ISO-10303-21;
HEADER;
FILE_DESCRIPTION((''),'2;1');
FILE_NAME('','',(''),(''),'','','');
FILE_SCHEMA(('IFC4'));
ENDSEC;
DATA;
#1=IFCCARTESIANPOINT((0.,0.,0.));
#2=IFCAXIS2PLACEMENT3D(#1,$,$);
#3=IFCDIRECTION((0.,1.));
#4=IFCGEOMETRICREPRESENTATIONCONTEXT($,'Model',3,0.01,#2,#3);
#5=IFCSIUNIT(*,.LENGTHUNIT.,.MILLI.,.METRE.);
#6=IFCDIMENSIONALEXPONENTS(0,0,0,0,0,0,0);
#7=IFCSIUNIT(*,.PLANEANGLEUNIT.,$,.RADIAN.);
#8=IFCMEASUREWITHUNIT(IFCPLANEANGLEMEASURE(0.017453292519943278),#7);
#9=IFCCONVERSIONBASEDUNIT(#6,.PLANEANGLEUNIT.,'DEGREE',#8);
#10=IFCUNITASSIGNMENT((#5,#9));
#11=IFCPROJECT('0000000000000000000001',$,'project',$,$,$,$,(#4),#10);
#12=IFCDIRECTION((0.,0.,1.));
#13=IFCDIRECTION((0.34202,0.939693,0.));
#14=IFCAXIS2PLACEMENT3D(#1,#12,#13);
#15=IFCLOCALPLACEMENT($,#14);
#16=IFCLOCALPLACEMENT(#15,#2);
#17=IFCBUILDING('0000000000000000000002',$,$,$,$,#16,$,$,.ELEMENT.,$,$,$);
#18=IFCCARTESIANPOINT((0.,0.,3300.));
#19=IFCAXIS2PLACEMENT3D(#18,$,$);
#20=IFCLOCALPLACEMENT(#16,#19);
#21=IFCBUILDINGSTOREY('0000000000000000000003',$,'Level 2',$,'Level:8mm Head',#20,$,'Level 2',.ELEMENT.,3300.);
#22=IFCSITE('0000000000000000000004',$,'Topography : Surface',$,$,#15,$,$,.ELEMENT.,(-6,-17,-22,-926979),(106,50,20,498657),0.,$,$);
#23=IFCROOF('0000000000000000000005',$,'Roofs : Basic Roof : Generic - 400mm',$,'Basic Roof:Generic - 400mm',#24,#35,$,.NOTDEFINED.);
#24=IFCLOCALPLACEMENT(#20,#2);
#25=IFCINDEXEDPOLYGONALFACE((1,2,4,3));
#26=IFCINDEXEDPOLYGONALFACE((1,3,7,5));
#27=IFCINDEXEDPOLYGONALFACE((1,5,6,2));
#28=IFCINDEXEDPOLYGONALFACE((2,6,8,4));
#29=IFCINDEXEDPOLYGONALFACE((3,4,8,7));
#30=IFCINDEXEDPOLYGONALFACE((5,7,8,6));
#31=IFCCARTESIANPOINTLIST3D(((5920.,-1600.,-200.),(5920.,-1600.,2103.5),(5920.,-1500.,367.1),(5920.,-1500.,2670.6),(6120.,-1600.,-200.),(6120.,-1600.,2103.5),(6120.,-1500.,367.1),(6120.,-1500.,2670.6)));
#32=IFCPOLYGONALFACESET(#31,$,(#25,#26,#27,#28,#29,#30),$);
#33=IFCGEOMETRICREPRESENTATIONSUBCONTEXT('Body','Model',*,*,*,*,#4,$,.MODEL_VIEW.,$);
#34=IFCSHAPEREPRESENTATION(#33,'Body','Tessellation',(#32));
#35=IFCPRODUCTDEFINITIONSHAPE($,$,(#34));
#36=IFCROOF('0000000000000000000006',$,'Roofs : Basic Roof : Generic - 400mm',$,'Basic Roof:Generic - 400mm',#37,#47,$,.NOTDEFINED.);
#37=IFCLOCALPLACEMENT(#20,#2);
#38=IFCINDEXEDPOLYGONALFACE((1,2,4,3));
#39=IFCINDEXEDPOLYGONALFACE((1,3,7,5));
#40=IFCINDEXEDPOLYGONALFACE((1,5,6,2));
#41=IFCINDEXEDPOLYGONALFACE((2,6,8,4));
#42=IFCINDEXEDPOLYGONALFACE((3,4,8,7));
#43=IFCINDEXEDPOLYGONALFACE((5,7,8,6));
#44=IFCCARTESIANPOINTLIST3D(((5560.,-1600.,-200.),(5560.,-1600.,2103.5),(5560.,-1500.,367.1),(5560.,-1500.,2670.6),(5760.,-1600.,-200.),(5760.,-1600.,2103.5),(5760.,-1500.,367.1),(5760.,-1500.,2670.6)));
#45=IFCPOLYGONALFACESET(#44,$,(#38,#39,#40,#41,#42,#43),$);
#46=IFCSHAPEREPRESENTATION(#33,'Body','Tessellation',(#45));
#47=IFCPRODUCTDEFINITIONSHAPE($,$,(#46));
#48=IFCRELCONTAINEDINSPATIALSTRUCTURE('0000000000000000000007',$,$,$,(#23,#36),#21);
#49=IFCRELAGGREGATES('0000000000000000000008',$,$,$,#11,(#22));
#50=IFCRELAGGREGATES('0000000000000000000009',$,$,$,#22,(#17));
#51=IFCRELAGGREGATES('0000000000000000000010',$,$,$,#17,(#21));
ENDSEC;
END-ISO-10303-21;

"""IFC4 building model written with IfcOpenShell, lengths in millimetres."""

from ifc_helpers import new_model, entity, si_unit, converted_unit, direction, frame, origin, place, context, subcontext, project, spatial, indexed_curve, outline, extrude, element, save


model = new_model("IFC4")

# Units and contexts
model_context = context("Model", 3, precision=0.01, world=origin(), true_north=direction((0.0, 1.0)))
body_context = subcontext(model_context, "Body", "Model", "MODEL_VIEW")
ifc_project = project(units=[si_unit("LENGTHUNIT", "METRE", prefix="MILLI"), converted_unit("PLANEANGLEUNIT", "DEGREE", entity("IfcPlaneAngleMeasure", 0.017453292519943278), si_unit("PLANEANGLEUNIT", "RADIAN"), dimensions=[0, 0, 0, 0, 0, 0, 0])], contexts=[model_context])

# Site, building, storey
site_placement = place(None, frame((0.0, 0.0, 0.0), z_axis=(0.0, 0.0, 1.0), x_axis=(0.34202, 0.939693, 0.0)))
site = spatial("IfcSite", under=ifc_project, at=site_placement, Name="Topography : Surface", CompositionType="ELEMENT", RefLatitude=(-6, -17, -22, -926979), RefLongitude=(106, 50, 20, 498657), RefElevation=0.0)
building_placement = place(site_placement, origin())
building = spatial("IfcBuilding", under=site, at=building_placement, CompositionType="ELEMENT")
storey_placement = place(building_placement, frame((0.0, 0.0, 3300.0)))
storey = spatial("IfcBuildingStorey", under=building, at=storey_placement, Name="Level 2", ObjectType="Level:8mm Head", LongName="Level 2", CompositionType="ELEMENT", Elevation=3300.0)

# Roofs
for number, where, name in (
    (1, (5920.0, -1600.0, -200.0), "Roofs : Basic Roof : Generic - 400mm"),
    (2, (5560.0, -1600.0, -200.0), "Roofs : Basic Roof : Generic - 400mm"),
):
    element("IfcRoof", number, at=place(storey_placement, frame(where)), inside=storey, Name=name, ObjectType="Basic Roof:Generic - 400mm", PredefinedType="NOTDEFINED", context=body_context, shape_type="SweptSolid", body=[
        extrude(outline(indexed_curve([(100.0, 287.9), (-100.0, 287.9), (-100.0, -287.9), (100.0, -287.9), (100.0, 287.9)], self_intersect=False)), frame((100.0, 50.0, 283.6), z_axis=(0.0, -0.984808, 0.173648), x_axis=(1.0, 0.0, 0.0)), (0.0, 0.984808, 0.173648), 2303.5),
    ])

save(model, "model.ifc")
